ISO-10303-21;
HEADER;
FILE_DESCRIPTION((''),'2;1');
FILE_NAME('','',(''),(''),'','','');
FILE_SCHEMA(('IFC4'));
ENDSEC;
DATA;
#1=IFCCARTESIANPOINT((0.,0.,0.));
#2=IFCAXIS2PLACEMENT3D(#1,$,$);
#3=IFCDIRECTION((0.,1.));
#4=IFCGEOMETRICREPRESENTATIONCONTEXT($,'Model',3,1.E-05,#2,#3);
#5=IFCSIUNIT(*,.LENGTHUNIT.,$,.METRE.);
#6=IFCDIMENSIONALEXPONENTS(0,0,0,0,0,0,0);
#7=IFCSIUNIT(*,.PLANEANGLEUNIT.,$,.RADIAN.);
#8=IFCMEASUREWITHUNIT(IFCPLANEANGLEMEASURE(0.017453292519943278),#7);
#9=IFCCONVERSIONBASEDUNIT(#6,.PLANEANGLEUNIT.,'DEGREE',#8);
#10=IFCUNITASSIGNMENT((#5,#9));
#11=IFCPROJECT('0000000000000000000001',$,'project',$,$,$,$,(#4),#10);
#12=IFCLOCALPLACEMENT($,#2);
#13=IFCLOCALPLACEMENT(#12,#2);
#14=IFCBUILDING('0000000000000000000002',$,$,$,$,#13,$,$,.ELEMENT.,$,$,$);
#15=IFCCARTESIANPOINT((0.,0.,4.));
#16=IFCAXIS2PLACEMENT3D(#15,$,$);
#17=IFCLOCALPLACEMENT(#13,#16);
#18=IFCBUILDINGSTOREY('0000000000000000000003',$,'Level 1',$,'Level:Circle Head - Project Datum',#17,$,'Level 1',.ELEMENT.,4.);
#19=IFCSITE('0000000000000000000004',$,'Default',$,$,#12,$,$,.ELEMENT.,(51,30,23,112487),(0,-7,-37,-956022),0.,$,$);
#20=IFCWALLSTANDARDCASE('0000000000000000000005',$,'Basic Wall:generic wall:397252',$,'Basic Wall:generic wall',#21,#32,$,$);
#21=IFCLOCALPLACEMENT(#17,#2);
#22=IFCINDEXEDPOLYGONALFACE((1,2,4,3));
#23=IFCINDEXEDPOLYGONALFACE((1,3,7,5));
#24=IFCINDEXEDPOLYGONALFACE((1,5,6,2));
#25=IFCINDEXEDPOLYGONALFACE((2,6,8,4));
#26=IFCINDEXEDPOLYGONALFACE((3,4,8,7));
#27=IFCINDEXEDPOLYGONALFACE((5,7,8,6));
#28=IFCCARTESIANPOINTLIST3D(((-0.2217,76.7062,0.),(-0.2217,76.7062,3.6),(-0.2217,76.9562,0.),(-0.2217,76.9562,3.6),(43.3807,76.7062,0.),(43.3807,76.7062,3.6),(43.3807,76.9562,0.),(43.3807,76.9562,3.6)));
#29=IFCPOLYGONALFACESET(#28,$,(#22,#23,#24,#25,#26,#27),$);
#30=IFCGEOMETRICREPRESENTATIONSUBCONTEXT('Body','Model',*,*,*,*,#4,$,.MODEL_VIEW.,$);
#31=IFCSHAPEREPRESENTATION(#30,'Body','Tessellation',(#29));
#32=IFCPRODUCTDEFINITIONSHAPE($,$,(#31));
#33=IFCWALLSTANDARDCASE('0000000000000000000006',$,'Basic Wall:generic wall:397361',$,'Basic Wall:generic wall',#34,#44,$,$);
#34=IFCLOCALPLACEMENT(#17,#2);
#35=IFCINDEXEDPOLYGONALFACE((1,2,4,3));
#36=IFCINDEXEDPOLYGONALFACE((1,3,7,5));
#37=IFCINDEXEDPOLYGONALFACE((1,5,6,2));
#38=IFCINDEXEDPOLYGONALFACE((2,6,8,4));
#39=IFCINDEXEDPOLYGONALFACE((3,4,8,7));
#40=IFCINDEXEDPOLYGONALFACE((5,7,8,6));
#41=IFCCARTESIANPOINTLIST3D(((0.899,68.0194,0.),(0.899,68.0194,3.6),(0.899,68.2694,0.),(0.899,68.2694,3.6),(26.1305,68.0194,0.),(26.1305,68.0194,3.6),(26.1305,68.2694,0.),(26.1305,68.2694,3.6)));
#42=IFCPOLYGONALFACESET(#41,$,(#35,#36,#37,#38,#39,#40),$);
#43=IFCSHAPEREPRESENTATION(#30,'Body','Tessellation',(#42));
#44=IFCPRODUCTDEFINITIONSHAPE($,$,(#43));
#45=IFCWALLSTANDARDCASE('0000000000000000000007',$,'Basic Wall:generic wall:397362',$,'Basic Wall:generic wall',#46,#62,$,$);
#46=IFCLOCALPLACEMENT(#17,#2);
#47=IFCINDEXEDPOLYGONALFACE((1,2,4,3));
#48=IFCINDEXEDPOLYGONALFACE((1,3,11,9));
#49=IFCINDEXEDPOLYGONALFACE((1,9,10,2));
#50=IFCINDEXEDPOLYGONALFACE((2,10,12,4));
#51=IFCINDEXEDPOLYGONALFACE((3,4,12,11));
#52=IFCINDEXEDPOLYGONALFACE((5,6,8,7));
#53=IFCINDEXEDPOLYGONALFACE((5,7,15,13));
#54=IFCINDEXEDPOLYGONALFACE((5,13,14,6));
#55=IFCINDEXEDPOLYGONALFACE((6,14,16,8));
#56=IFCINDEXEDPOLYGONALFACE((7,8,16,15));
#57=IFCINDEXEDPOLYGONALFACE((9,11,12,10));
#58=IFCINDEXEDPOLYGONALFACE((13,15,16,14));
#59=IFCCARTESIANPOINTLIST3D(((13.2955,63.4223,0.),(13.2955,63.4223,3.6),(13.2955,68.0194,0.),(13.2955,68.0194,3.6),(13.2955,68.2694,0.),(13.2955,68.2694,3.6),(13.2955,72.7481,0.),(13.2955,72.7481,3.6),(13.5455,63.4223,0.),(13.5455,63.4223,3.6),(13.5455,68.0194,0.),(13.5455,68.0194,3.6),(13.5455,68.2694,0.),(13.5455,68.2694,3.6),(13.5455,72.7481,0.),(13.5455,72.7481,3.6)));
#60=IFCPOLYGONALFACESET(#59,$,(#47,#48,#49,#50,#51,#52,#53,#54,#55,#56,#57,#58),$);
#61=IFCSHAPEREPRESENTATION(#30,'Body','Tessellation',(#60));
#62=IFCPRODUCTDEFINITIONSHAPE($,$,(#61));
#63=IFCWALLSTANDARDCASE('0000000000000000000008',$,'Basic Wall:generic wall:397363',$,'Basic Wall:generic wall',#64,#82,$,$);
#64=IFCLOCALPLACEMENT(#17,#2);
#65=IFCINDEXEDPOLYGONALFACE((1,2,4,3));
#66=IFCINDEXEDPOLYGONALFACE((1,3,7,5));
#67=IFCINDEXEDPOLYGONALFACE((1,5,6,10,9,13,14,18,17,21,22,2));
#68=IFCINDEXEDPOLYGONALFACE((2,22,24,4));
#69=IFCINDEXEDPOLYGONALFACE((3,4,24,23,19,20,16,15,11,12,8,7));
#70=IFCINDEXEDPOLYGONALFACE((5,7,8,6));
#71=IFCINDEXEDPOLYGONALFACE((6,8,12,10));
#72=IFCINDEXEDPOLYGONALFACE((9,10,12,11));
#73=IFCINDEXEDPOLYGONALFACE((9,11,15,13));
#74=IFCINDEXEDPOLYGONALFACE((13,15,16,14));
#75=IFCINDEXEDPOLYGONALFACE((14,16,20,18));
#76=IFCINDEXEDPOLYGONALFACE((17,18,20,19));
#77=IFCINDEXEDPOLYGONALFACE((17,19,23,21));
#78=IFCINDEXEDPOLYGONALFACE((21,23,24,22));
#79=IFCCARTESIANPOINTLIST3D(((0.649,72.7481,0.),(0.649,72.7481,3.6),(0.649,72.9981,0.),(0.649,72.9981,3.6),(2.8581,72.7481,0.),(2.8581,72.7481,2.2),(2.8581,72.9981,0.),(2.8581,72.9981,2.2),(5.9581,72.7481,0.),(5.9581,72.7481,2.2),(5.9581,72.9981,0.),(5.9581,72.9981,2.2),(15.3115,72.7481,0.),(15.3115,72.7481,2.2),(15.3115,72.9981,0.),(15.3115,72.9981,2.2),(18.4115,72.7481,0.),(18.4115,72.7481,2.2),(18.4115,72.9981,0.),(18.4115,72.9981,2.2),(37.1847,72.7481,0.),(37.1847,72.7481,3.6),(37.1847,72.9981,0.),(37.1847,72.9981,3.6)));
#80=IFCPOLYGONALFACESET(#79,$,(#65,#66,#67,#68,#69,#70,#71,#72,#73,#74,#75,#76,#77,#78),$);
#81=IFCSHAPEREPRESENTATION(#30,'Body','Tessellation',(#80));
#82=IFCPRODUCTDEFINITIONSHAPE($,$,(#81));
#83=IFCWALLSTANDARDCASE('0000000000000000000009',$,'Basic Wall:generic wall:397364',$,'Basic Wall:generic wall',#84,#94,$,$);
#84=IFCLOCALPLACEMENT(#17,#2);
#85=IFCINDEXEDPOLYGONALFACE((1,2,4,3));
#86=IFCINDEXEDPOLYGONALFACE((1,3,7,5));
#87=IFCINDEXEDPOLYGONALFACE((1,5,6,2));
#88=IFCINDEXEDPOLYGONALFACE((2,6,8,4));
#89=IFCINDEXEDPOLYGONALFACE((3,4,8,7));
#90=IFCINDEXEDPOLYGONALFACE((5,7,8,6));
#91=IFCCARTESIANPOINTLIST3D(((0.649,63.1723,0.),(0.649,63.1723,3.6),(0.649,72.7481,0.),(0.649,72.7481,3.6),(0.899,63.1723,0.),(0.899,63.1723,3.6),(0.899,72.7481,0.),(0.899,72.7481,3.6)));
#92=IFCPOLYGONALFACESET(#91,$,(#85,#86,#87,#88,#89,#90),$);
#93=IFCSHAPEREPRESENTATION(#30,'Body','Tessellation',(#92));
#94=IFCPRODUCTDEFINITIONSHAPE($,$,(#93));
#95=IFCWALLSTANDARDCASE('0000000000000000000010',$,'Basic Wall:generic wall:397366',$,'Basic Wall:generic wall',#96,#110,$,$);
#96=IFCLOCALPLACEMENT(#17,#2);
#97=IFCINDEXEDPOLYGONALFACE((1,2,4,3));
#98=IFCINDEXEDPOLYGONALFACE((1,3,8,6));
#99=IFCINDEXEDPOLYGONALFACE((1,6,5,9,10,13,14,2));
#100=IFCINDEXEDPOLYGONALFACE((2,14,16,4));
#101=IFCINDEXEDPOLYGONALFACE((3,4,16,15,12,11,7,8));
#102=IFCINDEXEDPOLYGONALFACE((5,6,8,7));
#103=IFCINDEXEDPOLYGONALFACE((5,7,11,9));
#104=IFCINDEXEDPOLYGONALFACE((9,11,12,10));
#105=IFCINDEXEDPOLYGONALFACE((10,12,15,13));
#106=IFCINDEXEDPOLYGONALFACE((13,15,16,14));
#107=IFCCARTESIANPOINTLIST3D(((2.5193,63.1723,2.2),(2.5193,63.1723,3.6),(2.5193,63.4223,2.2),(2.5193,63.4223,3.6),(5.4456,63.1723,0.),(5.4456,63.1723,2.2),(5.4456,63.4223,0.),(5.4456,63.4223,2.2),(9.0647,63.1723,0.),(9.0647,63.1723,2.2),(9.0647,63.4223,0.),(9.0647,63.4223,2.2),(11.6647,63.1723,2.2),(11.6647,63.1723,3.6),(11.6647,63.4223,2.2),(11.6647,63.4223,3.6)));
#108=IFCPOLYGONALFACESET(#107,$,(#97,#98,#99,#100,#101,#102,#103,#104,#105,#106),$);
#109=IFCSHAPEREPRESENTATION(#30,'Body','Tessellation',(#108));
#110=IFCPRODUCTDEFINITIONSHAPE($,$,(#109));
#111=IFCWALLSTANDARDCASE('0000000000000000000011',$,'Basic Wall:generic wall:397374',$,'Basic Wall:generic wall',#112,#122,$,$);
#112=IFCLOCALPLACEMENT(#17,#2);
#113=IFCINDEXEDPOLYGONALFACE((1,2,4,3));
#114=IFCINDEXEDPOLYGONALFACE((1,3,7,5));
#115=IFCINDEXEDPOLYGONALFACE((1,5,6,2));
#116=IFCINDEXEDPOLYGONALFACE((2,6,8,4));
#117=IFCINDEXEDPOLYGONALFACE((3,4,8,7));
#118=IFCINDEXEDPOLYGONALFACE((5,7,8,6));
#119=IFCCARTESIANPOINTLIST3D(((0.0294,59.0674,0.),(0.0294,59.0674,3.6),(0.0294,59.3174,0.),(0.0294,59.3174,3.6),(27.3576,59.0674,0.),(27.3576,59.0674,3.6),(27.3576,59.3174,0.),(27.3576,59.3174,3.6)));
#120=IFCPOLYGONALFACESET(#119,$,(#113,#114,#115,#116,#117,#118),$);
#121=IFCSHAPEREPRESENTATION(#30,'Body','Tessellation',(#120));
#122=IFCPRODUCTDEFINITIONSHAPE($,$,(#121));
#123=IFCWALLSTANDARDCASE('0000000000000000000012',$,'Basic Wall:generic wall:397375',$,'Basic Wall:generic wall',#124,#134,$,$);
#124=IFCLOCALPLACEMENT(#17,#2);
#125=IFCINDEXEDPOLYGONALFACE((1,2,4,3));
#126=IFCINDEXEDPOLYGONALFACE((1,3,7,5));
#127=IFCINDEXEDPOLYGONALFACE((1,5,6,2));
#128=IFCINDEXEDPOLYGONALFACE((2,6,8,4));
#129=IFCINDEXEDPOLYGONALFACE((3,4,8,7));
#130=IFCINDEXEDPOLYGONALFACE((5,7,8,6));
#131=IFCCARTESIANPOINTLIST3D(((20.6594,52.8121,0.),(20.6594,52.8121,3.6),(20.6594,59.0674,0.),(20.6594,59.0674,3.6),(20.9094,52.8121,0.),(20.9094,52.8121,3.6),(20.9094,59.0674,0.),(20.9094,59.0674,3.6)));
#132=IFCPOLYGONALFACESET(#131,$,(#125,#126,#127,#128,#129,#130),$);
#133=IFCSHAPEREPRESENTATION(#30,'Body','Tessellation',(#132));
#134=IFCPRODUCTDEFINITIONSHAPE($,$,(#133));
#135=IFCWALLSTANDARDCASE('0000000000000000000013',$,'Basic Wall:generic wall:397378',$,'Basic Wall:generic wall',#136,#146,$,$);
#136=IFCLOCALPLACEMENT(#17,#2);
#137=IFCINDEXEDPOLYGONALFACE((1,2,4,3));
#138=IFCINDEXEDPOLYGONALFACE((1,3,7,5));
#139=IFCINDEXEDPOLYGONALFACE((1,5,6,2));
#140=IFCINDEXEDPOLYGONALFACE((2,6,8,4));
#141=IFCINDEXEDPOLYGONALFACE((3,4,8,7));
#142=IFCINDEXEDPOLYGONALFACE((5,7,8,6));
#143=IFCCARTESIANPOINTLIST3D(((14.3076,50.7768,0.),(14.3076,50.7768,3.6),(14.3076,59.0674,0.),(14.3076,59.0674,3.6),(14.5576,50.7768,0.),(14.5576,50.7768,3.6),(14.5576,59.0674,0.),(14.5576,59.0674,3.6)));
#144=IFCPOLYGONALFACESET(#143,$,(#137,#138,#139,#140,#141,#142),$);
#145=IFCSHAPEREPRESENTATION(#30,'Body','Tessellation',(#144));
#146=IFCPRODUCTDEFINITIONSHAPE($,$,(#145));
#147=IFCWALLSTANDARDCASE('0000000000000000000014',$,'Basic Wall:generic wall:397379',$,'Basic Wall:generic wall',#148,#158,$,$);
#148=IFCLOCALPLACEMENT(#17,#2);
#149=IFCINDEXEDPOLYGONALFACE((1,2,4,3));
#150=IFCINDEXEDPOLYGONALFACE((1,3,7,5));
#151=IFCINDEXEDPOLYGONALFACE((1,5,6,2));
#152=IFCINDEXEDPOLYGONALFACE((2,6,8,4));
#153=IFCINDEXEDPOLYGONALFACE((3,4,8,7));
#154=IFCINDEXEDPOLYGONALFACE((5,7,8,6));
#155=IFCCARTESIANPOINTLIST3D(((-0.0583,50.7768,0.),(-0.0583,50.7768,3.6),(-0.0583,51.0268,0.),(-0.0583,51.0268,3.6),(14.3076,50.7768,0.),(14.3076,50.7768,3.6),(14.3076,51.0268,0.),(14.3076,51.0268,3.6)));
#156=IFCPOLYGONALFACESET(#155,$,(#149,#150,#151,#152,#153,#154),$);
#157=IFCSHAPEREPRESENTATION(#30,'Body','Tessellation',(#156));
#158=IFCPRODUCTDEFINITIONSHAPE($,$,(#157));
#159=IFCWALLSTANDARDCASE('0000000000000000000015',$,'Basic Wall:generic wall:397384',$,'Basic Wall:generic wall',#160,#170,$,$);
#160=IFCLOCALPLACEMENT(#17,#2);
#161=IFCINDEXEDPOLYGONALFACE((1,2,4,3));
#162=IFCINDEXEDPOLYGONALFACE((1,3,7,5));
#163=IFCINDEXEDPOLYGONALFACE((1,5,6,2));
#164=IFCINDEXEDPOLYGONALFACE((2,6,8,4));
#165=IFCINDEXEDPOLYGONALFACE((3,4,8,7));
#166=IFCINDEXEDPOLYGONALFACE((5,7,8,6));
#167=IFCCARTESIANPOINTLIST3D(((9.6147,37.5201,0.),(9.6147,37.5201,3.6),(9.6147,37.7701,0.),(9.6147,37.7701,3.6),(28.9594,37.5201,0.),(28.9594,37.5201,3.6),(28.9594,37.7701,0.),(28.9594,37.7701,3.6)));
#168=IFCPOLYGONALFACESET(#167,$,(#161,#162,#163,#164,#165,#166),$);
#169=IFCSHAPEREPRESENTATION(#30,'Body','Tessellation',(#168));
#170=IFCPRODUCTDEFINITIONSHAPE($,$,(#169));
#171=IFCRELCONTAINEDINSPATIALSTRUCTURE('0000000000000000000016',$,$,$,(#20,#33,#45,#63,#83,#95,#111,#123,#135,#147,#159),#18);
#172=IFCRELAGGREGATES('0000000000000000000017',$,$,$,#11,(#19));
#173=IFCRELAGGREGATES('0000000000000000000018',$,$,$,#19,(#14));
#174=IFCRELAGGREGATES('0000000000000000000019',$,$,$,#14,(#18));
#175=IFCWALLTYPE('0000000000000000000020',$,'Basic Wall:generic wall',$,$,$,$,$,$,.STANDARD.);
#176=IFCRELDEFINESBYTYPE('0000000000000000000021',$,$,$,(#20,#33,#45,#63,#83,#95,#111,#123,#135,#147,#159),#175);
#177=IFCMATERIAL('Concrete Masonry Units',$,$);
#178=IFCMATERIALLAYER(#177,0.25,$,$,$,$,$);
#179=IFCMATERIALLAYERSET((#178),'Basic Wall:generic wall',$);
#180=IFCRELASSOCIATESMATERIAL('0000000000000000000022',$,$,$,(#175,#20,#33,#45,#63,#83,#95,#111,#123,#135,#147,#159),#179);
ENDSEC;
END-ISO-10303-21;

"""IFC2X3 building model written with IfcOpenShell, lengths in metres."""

from ifc_helpers import new_model, entity, si_unit, converted_unit, direction, frame, frame_2d, origin, place, context, subcontext, project, spatial, rectangle, extrude, material, layer, layer_set, layer_usage, type_object, element, save


model = new_model("IFC2X3")

# Units and contexts
model_context = context("Model", 3, precision=1e-05, world=origin(), true_north=direction((0.0, 1.0)))
body_context = subcontext(model_context, "Body", "Model", "MODEL_VIEW")
ifc_project = project(units=[si_unit("LENGTHUNIT", "METRE"), converted_unit("PLANEANGLEUNIT", "DEGREE", entity("IfcPlaneAngleMeasure", 0.017453292519943278), si_unit("PLANEANGLEUNIT", "RADIAN"), dimensions=[0, 0, 0, 0, 0, 0, 0])], contexts=[model_context])

# Site, building, storey
site_placement = place(None, origin())
site = spatial("IfcSite", under=ifc_project, at=site_placement, Name="Default", CompositionType="ELEMENT", RefLatitude=(51, 30, 23, 112487), RefLongitude=(0, -7, -37, -956022), RefElevation=0.0)
building_placement = place(site_placement, origin())
building = spatial("IfcBuilding", under=site, at=building_placement, CompositionType="ELEMENT")
storey_placement = place(building_placement, frame((0.0, 0.0, 4.0)))
storey = spatial("IfcBuildingStorey", under=building, at=storey_placement, Name="Level 1", ObjectType="Level:Circle Head - Project Datum", LongName="Level 1", CompositionType="ELEMENT", Elevation=4.0)

# Walls
ifc_material_1 = material(Name="Concrete Masonry Units")
ifc_layer_1 = layer(ifc_material_1, 0.25)
ifc_layer_set_1 = layer_set([ifc_layer_1], Name="Basic Wall:generic wall")
ifc_layer_usage_1 = layer_usage(ifc_layer_set_1, "AXIS2", "POSITIVE", -0.125)
wall_type_1 = type_object("IfcWallType", Name="Basic Wall:generic wall", PredefinedType="STANDARD", material=ifc_layer_set_1)
wall_1_placement = place(storey_placement, frame((-0.2217, 76.8312, 0.0)))
element("IfcWallStandardCase", 1, at=wall_1_placement, inside=storey, type_object=wall_type_1, material=ifc_layer_usage_1, Name="Basic Wall:generic wall:397252", ObjectType="Basic Wall:generic wall", context=body_context, shape_type="SweptSolid", body=[
    extrude(rectangle(XDim=43.6023, YDim=0.25, at=frame_2d((21.8012, 0.0), x_axis=(-1.0, 0.0))), origin(), (0.0, 0.0, 1.0), 3.6),
])
ifc_layer_usage_2 = layer_usage(ifc_layer_set_1, "AXIS2", "NEGATIVE", 0.125)
wall_2_placement = place(storey_placement, frame((0.899, 68.1444, 0.0)))
element("IfcWallStandardCase", 2, at=wall_2_placement, inside=storey, type_object=wall_type_1, material=ifc_layer_usage_2, Name="Basic Wall:generic wall:397361", ObjectType="Basic Wall:generic wall", context=body_context, shape_type="SweptSolid", body=[
    extrude(rectangle(XDim=25.2315, YDim=0.25, at=frame_2d((12.6158, 0.0), x_axis=(-1.0, 0.0))), origin(), (0.0, 0.0, 1.0), 3.6),
])

# Wall, opening
ifc_layer_usage_3 = layer_usage(ifc_layer_set_1, "AXIS2", "NEGATIVE", 0.125)
wall_3_placement = place(storey_placement, frame((13.4205, 72.7481, 0.0), z_axis=(0.0, 0.0, 1.0), x_axis=(0.0, -1.0, 0.0)))
wall_3 = element("IfcWallStandardCase", 3, at=wall_3_placement, inside=storey, type_object=wall_type_1, material=ifc_layer_usage_3, Name="Basic Wall:generic wall:397362", ObjectType="Basic Wall:generic wall", context=body_context, shape_type="SweptSolid", body=[
    extrude(rectangle(XDim=9.3259, YDim=0.25, at=frame_2d((4.6629, 0.0), x_axis=(-1.0, 0.0))), origin(), (0.0, 0.0, 1.0), 3.6),
])
opening_1_placement = place(storey_placement, frame((13.4205, 72.7481, 0.0), z_axis=(0.0, 0.0, 1.0), x_axis=(0.0, -1.0, 0.0)))
element("IfcOpeningElement", 4, at=opening_1_placement, cuts=wall_3, ObjectType="Opening", context=body_context, shape_type="SweptSolid", body=[
    extrude(rectangle(XDim=3.6, YDim=0.25, at=frame_2d((0.0, 0.0), x_axis=(1.0, 0.0))), frame((4.7287, 0.0, 1.8), z_axis=(-1.0, 0.0, 0.0), x_axis=(0.0, 0.0, 1.0)), (0.0, 0.0, 1.0), 0.25),
])

# Wall, openings
ifc_layer_usage_4 = layer_usage(ifc_layer_set_1, "AXIS2", "NEGATIVE", 0.125)
wall_4_placement = place(storey_placement, frame((0.649, 72.8731, 0.0)))
wall_4 = element("IfcWallStandardCase", 5, at=wall_4_placement, inside=storey, type_object=wall_type_1, material=ifc_layer_usage_4, Name="Basic Wall:generic wall:397363", ObjectType="Basic Wall:generic wall", context=body_context, shape_type="SweptSolid", body=[
    extrude(rectangle(XDim=36.5356, YDim=0.25, at=frame_2d((18.2678, 0.0), x_axis=(1.0, 0.0))), origin(), (0.0, 0.0, 1.0), 3.6),
])
opening_2_placement = place(wall_4_placement, frame((5.3091, 0.125, 0.0)))
element("IfcOpeningElement", 6, at=opening_2_placement, cuts=wall_4, ObjectType="Opening", context=body_context, shape_type="SweptSolid", body=[
    extrude(rectangle(XDim=2.2, YDim=3.1, at=frame_2d((1.1, 1.55), x_axis=(1.0, 0.0))), frame((0.0, 0.0, 0.0), z_axis=(0.0, -1.0, 0.0), x_axis=(0.0, 0.0, 1.0)), (0.0, 0.0, 1.0), 0.25),
])
opening_3_placement = place(wall_4_placement, frame((17.7625, 0.125, 0.0)))
element("IfcOpeningElement", 7, at=opening_3_placement, cuts=wall_4, ObjectType="Opening", context=body_context, shape_type="SweptSolid", body=[
    extrude(rectangle(XDim=2.2, YDim=3.1, at=frame_2d((1.1, 1.55), x_axis=(1.0, 0.0))), frame((0.0, 0.0, 0.0), z_axis=(0.0, -1.0, 0.0), x_axis=(0.0, 0.0, 1.0)), (0.0, 0.0, 1.0), 0.25),
])

# Wall
ifc_layer_usage_5 = layer_usage(ifc_layer_set_1, "AXIS2", "NEGATIVE", 0.125)
wall_5_placement = place(storey_placement, frame((0.774, 63.1723, 0.0), z_axis=(0.0, 0.0, 1.0), x_axis=(0.0, 1.0, 0.0)))
element("IfcWallStandardCase", 8, at=wall_5_placement, inside=storey, type_object=wall_type_1, material=ifc_layer_usage_5, Name="Basic Wall:generic wall:397364", ObjectType="Basic Wall:generic wall", context=body_context, shape_type="SweptSolid", body=[
    extrude(rectangle(XDim=9.5759, YDim=0.25, at=frame_2d((4.7879, 0.0), x_axis=(-1.0, 0.0))), origin(), (0.0, 0.0, 1.0), 3.6),
])

# Wall, openings
ifc_layer_usage_6 = layer_usage(ifc_layer_set_1, "AXIS2", "NEGATIVE", 0.125)
wall_6_placement = place(storey_placement, frame((11.6647, 63.2973, 0.0), z_axis=(0.0, 0.0, 1.0), x_axis=(-1.0, 0.0, 0.0)))
wall_6 = element("IfcWallStandardCase", 9, at=wall_6_placement, inside=storey, type_object=wall_type_1, material=ifc_layer_usage_6, Name="Basic Wall:generic wall:397366", ObjectType="Basic Wall:generic wall", context=body_context, shape_type="SweptSolid", body=[
    extrude(rectangle(XDim=9.1454, YDim=0.25, at=frame_2d((4.5727, 0.0), x_axis=(-1.0, 0.0))), origin(), (0.0, 0.0, 1.0), 3.6),
])
opening_4_placement = place(wall_6_placement, frame((9.319, 0.125, 0.0)))
element("IfcOpeningElement", 10, at=opening_4_placement, cuts=wall_6, ObjectType="Opening", context=body_context, shape_type="SweptSolid", body=[
    extrude(rectangle(XDim=2.2, YDim=3.1, at=frame_2d((1.1, 1.55), x_axis=(1.0, 0.0))), frame((0.0, 0.0, 0.0), z_axis=(0.0, -1.0, 0.0), x_axis=(0.0, 0.0, 1.0)), (0.0, 0.0, 1.0), 0.25),
])
opening_5_placement = place(wall_6_placement, frame((2.6, 0.125, 0.0)))
element("IfcOpeningElement", 11, at=opening_5_placement, cuts=wall_6, ObjectType="Opening", context=body_context, shape_type="SweptSolid", body=[
    extrude(rectangle(XDim=2.2, YDim=3.1, at=frame_2d((1.1, 1.55), x_axis=(1.0, 0.0))), frame((0.0, 0.0, 0.0), z_axis=(0.0, -1.0, 0.0), x_axis=(0.0, 0.0, 1.0)), (0.0, 0.0, 1.0), 0.25),
])

# Walls
ifc_layer_usage_7 = layer_usage(ifc_layer_set_1, "AXIS2", "NEGATIVE", 0.125)
wall_7_placement = place(storey_placement, frame((0.0294, 59.1924, 0.0)))
element("IfcWallStandardCase", 12, at=wall_7_placement, inside=storey, type_object=wall_type_1, material=ifc_layer_usage_7, Name="Basic Wall:generic wall:397374", ObjectType="Basic Wall:generic wall", context=body_context, shape_type="SweptSolid", body=[
    extrude(rectangle(XDim=27.3282, YDim=0.25, at=frame_2d((13.6641, 0.0), x_axis=(-1.0, 0.0))), origin(), (0.0, 0.0, 1.0), 3.6),
])
ifc_layer_usage_8 = layer_usage(ifc_layer_set_1, "AXIS2", "NEGATIVE", 0.125)
wall_8_placement = place(storey_placement, frame((20.7844, 59.0674, 0.0), z_axis=(0.0, 0.0, 1.0), x_axis=(0.0, -1.0, 0.0)))
element("IfcWallStandardCase", 13, at=wall_8_placement, inside=storey, type_object=wall_type_1, material=ifc_layer_usage_8, Name="Basic Wall:generic wall:397375", ObjectType="Basic Wall:generic wall", context=body_context, shape_type="SweptSolid", body=[
    extrude(rectangle(XDim=6.2553, YDim=0.25, at=frame_2d((3.1276, 0.0), x_axis=(-1.0, 0.0))), origin(), (0.0, 0.0, 1.0), 3.6),
])
ifc_layer_usage_9 = layer_usage(ifc_layer_set_1, "AXIS2", "NEGATIVE", 0.125)
wall_9_placement = place(storey_placement, frame((14.4326, 50.7768, 0.0), z_axis=(0.0, 0.0, 1.0), x_axis=(0.0, 1.0, 0.0)))
element("IfcWallStandardCase", 14, at=wall_9_placement, inside=storey, type_object=wall_type_1, material=ifc_layer_usage_9, Name="Basic Wall:generic wall:397378", ObjectType="Basic Wall:generic wall", context=body_context, shape_type="SweptSolid", body=[
    extrude(rectangle(XDim=8.2906, YDim=0.25, at=frame_2d((4.1453, 0.0), x_axis=(-1.0, 0.0))), origin(), (0.0, 0.0, 1.0), 3.6),
])
ifc_layer_usage_10 = layer_usage(ifc_layer_set_1, "AXIS2", "NEGATIVE", 0.125)
wall_10_placement = place(storey_placement, frame((-0.0583, 50.9018, 0.0)))
element("IfcWallStandardCase", 15, at=wall_10_placement, inside=storey, type_object=wall_type_1, material=ifc_layer_usage_10, Name="Basic Wall:generic wall:397379", ObjectType="Basic Wall:generic wall", context=body_context, shape_type="SweptSolid", body=[
    extrude(rectangle(XDim=14.3659, YDim=0.25, at=frame_2d((7.1829, 0.0), x_axis=(-1.0, 0.0))), origin(), (0.0, 0.0, 1.0), 3.6),
])
ifc_layer_usage_11 = layer_usage(ifc_layer_set_1, "AXIS2", "NEGATIVE", 0.125)
wall_11_placement = place(storey_placement, frame((9.6147, 37.6451, 0.0)))
element("IfcWallStandardCase", 16, at=wall_11_placement, inside=storey, type_object=wall_type_1, material=ifc_layer_usage_11, Name="Basic Wall:generic wall:397384", ObjectType="Basic Wall:generic wall", context=body_context, shape_type="SweptSolid", body=[
    extrude(rectangle(XDim=19.3447, YDim=0.25, at=frame_2d((9.6723, 0.0), x_axis=(-1.0, 0.0))), origin(), (0.0, 0.0, 1.0), 3.6),
])

save(model, "model.ifc")
